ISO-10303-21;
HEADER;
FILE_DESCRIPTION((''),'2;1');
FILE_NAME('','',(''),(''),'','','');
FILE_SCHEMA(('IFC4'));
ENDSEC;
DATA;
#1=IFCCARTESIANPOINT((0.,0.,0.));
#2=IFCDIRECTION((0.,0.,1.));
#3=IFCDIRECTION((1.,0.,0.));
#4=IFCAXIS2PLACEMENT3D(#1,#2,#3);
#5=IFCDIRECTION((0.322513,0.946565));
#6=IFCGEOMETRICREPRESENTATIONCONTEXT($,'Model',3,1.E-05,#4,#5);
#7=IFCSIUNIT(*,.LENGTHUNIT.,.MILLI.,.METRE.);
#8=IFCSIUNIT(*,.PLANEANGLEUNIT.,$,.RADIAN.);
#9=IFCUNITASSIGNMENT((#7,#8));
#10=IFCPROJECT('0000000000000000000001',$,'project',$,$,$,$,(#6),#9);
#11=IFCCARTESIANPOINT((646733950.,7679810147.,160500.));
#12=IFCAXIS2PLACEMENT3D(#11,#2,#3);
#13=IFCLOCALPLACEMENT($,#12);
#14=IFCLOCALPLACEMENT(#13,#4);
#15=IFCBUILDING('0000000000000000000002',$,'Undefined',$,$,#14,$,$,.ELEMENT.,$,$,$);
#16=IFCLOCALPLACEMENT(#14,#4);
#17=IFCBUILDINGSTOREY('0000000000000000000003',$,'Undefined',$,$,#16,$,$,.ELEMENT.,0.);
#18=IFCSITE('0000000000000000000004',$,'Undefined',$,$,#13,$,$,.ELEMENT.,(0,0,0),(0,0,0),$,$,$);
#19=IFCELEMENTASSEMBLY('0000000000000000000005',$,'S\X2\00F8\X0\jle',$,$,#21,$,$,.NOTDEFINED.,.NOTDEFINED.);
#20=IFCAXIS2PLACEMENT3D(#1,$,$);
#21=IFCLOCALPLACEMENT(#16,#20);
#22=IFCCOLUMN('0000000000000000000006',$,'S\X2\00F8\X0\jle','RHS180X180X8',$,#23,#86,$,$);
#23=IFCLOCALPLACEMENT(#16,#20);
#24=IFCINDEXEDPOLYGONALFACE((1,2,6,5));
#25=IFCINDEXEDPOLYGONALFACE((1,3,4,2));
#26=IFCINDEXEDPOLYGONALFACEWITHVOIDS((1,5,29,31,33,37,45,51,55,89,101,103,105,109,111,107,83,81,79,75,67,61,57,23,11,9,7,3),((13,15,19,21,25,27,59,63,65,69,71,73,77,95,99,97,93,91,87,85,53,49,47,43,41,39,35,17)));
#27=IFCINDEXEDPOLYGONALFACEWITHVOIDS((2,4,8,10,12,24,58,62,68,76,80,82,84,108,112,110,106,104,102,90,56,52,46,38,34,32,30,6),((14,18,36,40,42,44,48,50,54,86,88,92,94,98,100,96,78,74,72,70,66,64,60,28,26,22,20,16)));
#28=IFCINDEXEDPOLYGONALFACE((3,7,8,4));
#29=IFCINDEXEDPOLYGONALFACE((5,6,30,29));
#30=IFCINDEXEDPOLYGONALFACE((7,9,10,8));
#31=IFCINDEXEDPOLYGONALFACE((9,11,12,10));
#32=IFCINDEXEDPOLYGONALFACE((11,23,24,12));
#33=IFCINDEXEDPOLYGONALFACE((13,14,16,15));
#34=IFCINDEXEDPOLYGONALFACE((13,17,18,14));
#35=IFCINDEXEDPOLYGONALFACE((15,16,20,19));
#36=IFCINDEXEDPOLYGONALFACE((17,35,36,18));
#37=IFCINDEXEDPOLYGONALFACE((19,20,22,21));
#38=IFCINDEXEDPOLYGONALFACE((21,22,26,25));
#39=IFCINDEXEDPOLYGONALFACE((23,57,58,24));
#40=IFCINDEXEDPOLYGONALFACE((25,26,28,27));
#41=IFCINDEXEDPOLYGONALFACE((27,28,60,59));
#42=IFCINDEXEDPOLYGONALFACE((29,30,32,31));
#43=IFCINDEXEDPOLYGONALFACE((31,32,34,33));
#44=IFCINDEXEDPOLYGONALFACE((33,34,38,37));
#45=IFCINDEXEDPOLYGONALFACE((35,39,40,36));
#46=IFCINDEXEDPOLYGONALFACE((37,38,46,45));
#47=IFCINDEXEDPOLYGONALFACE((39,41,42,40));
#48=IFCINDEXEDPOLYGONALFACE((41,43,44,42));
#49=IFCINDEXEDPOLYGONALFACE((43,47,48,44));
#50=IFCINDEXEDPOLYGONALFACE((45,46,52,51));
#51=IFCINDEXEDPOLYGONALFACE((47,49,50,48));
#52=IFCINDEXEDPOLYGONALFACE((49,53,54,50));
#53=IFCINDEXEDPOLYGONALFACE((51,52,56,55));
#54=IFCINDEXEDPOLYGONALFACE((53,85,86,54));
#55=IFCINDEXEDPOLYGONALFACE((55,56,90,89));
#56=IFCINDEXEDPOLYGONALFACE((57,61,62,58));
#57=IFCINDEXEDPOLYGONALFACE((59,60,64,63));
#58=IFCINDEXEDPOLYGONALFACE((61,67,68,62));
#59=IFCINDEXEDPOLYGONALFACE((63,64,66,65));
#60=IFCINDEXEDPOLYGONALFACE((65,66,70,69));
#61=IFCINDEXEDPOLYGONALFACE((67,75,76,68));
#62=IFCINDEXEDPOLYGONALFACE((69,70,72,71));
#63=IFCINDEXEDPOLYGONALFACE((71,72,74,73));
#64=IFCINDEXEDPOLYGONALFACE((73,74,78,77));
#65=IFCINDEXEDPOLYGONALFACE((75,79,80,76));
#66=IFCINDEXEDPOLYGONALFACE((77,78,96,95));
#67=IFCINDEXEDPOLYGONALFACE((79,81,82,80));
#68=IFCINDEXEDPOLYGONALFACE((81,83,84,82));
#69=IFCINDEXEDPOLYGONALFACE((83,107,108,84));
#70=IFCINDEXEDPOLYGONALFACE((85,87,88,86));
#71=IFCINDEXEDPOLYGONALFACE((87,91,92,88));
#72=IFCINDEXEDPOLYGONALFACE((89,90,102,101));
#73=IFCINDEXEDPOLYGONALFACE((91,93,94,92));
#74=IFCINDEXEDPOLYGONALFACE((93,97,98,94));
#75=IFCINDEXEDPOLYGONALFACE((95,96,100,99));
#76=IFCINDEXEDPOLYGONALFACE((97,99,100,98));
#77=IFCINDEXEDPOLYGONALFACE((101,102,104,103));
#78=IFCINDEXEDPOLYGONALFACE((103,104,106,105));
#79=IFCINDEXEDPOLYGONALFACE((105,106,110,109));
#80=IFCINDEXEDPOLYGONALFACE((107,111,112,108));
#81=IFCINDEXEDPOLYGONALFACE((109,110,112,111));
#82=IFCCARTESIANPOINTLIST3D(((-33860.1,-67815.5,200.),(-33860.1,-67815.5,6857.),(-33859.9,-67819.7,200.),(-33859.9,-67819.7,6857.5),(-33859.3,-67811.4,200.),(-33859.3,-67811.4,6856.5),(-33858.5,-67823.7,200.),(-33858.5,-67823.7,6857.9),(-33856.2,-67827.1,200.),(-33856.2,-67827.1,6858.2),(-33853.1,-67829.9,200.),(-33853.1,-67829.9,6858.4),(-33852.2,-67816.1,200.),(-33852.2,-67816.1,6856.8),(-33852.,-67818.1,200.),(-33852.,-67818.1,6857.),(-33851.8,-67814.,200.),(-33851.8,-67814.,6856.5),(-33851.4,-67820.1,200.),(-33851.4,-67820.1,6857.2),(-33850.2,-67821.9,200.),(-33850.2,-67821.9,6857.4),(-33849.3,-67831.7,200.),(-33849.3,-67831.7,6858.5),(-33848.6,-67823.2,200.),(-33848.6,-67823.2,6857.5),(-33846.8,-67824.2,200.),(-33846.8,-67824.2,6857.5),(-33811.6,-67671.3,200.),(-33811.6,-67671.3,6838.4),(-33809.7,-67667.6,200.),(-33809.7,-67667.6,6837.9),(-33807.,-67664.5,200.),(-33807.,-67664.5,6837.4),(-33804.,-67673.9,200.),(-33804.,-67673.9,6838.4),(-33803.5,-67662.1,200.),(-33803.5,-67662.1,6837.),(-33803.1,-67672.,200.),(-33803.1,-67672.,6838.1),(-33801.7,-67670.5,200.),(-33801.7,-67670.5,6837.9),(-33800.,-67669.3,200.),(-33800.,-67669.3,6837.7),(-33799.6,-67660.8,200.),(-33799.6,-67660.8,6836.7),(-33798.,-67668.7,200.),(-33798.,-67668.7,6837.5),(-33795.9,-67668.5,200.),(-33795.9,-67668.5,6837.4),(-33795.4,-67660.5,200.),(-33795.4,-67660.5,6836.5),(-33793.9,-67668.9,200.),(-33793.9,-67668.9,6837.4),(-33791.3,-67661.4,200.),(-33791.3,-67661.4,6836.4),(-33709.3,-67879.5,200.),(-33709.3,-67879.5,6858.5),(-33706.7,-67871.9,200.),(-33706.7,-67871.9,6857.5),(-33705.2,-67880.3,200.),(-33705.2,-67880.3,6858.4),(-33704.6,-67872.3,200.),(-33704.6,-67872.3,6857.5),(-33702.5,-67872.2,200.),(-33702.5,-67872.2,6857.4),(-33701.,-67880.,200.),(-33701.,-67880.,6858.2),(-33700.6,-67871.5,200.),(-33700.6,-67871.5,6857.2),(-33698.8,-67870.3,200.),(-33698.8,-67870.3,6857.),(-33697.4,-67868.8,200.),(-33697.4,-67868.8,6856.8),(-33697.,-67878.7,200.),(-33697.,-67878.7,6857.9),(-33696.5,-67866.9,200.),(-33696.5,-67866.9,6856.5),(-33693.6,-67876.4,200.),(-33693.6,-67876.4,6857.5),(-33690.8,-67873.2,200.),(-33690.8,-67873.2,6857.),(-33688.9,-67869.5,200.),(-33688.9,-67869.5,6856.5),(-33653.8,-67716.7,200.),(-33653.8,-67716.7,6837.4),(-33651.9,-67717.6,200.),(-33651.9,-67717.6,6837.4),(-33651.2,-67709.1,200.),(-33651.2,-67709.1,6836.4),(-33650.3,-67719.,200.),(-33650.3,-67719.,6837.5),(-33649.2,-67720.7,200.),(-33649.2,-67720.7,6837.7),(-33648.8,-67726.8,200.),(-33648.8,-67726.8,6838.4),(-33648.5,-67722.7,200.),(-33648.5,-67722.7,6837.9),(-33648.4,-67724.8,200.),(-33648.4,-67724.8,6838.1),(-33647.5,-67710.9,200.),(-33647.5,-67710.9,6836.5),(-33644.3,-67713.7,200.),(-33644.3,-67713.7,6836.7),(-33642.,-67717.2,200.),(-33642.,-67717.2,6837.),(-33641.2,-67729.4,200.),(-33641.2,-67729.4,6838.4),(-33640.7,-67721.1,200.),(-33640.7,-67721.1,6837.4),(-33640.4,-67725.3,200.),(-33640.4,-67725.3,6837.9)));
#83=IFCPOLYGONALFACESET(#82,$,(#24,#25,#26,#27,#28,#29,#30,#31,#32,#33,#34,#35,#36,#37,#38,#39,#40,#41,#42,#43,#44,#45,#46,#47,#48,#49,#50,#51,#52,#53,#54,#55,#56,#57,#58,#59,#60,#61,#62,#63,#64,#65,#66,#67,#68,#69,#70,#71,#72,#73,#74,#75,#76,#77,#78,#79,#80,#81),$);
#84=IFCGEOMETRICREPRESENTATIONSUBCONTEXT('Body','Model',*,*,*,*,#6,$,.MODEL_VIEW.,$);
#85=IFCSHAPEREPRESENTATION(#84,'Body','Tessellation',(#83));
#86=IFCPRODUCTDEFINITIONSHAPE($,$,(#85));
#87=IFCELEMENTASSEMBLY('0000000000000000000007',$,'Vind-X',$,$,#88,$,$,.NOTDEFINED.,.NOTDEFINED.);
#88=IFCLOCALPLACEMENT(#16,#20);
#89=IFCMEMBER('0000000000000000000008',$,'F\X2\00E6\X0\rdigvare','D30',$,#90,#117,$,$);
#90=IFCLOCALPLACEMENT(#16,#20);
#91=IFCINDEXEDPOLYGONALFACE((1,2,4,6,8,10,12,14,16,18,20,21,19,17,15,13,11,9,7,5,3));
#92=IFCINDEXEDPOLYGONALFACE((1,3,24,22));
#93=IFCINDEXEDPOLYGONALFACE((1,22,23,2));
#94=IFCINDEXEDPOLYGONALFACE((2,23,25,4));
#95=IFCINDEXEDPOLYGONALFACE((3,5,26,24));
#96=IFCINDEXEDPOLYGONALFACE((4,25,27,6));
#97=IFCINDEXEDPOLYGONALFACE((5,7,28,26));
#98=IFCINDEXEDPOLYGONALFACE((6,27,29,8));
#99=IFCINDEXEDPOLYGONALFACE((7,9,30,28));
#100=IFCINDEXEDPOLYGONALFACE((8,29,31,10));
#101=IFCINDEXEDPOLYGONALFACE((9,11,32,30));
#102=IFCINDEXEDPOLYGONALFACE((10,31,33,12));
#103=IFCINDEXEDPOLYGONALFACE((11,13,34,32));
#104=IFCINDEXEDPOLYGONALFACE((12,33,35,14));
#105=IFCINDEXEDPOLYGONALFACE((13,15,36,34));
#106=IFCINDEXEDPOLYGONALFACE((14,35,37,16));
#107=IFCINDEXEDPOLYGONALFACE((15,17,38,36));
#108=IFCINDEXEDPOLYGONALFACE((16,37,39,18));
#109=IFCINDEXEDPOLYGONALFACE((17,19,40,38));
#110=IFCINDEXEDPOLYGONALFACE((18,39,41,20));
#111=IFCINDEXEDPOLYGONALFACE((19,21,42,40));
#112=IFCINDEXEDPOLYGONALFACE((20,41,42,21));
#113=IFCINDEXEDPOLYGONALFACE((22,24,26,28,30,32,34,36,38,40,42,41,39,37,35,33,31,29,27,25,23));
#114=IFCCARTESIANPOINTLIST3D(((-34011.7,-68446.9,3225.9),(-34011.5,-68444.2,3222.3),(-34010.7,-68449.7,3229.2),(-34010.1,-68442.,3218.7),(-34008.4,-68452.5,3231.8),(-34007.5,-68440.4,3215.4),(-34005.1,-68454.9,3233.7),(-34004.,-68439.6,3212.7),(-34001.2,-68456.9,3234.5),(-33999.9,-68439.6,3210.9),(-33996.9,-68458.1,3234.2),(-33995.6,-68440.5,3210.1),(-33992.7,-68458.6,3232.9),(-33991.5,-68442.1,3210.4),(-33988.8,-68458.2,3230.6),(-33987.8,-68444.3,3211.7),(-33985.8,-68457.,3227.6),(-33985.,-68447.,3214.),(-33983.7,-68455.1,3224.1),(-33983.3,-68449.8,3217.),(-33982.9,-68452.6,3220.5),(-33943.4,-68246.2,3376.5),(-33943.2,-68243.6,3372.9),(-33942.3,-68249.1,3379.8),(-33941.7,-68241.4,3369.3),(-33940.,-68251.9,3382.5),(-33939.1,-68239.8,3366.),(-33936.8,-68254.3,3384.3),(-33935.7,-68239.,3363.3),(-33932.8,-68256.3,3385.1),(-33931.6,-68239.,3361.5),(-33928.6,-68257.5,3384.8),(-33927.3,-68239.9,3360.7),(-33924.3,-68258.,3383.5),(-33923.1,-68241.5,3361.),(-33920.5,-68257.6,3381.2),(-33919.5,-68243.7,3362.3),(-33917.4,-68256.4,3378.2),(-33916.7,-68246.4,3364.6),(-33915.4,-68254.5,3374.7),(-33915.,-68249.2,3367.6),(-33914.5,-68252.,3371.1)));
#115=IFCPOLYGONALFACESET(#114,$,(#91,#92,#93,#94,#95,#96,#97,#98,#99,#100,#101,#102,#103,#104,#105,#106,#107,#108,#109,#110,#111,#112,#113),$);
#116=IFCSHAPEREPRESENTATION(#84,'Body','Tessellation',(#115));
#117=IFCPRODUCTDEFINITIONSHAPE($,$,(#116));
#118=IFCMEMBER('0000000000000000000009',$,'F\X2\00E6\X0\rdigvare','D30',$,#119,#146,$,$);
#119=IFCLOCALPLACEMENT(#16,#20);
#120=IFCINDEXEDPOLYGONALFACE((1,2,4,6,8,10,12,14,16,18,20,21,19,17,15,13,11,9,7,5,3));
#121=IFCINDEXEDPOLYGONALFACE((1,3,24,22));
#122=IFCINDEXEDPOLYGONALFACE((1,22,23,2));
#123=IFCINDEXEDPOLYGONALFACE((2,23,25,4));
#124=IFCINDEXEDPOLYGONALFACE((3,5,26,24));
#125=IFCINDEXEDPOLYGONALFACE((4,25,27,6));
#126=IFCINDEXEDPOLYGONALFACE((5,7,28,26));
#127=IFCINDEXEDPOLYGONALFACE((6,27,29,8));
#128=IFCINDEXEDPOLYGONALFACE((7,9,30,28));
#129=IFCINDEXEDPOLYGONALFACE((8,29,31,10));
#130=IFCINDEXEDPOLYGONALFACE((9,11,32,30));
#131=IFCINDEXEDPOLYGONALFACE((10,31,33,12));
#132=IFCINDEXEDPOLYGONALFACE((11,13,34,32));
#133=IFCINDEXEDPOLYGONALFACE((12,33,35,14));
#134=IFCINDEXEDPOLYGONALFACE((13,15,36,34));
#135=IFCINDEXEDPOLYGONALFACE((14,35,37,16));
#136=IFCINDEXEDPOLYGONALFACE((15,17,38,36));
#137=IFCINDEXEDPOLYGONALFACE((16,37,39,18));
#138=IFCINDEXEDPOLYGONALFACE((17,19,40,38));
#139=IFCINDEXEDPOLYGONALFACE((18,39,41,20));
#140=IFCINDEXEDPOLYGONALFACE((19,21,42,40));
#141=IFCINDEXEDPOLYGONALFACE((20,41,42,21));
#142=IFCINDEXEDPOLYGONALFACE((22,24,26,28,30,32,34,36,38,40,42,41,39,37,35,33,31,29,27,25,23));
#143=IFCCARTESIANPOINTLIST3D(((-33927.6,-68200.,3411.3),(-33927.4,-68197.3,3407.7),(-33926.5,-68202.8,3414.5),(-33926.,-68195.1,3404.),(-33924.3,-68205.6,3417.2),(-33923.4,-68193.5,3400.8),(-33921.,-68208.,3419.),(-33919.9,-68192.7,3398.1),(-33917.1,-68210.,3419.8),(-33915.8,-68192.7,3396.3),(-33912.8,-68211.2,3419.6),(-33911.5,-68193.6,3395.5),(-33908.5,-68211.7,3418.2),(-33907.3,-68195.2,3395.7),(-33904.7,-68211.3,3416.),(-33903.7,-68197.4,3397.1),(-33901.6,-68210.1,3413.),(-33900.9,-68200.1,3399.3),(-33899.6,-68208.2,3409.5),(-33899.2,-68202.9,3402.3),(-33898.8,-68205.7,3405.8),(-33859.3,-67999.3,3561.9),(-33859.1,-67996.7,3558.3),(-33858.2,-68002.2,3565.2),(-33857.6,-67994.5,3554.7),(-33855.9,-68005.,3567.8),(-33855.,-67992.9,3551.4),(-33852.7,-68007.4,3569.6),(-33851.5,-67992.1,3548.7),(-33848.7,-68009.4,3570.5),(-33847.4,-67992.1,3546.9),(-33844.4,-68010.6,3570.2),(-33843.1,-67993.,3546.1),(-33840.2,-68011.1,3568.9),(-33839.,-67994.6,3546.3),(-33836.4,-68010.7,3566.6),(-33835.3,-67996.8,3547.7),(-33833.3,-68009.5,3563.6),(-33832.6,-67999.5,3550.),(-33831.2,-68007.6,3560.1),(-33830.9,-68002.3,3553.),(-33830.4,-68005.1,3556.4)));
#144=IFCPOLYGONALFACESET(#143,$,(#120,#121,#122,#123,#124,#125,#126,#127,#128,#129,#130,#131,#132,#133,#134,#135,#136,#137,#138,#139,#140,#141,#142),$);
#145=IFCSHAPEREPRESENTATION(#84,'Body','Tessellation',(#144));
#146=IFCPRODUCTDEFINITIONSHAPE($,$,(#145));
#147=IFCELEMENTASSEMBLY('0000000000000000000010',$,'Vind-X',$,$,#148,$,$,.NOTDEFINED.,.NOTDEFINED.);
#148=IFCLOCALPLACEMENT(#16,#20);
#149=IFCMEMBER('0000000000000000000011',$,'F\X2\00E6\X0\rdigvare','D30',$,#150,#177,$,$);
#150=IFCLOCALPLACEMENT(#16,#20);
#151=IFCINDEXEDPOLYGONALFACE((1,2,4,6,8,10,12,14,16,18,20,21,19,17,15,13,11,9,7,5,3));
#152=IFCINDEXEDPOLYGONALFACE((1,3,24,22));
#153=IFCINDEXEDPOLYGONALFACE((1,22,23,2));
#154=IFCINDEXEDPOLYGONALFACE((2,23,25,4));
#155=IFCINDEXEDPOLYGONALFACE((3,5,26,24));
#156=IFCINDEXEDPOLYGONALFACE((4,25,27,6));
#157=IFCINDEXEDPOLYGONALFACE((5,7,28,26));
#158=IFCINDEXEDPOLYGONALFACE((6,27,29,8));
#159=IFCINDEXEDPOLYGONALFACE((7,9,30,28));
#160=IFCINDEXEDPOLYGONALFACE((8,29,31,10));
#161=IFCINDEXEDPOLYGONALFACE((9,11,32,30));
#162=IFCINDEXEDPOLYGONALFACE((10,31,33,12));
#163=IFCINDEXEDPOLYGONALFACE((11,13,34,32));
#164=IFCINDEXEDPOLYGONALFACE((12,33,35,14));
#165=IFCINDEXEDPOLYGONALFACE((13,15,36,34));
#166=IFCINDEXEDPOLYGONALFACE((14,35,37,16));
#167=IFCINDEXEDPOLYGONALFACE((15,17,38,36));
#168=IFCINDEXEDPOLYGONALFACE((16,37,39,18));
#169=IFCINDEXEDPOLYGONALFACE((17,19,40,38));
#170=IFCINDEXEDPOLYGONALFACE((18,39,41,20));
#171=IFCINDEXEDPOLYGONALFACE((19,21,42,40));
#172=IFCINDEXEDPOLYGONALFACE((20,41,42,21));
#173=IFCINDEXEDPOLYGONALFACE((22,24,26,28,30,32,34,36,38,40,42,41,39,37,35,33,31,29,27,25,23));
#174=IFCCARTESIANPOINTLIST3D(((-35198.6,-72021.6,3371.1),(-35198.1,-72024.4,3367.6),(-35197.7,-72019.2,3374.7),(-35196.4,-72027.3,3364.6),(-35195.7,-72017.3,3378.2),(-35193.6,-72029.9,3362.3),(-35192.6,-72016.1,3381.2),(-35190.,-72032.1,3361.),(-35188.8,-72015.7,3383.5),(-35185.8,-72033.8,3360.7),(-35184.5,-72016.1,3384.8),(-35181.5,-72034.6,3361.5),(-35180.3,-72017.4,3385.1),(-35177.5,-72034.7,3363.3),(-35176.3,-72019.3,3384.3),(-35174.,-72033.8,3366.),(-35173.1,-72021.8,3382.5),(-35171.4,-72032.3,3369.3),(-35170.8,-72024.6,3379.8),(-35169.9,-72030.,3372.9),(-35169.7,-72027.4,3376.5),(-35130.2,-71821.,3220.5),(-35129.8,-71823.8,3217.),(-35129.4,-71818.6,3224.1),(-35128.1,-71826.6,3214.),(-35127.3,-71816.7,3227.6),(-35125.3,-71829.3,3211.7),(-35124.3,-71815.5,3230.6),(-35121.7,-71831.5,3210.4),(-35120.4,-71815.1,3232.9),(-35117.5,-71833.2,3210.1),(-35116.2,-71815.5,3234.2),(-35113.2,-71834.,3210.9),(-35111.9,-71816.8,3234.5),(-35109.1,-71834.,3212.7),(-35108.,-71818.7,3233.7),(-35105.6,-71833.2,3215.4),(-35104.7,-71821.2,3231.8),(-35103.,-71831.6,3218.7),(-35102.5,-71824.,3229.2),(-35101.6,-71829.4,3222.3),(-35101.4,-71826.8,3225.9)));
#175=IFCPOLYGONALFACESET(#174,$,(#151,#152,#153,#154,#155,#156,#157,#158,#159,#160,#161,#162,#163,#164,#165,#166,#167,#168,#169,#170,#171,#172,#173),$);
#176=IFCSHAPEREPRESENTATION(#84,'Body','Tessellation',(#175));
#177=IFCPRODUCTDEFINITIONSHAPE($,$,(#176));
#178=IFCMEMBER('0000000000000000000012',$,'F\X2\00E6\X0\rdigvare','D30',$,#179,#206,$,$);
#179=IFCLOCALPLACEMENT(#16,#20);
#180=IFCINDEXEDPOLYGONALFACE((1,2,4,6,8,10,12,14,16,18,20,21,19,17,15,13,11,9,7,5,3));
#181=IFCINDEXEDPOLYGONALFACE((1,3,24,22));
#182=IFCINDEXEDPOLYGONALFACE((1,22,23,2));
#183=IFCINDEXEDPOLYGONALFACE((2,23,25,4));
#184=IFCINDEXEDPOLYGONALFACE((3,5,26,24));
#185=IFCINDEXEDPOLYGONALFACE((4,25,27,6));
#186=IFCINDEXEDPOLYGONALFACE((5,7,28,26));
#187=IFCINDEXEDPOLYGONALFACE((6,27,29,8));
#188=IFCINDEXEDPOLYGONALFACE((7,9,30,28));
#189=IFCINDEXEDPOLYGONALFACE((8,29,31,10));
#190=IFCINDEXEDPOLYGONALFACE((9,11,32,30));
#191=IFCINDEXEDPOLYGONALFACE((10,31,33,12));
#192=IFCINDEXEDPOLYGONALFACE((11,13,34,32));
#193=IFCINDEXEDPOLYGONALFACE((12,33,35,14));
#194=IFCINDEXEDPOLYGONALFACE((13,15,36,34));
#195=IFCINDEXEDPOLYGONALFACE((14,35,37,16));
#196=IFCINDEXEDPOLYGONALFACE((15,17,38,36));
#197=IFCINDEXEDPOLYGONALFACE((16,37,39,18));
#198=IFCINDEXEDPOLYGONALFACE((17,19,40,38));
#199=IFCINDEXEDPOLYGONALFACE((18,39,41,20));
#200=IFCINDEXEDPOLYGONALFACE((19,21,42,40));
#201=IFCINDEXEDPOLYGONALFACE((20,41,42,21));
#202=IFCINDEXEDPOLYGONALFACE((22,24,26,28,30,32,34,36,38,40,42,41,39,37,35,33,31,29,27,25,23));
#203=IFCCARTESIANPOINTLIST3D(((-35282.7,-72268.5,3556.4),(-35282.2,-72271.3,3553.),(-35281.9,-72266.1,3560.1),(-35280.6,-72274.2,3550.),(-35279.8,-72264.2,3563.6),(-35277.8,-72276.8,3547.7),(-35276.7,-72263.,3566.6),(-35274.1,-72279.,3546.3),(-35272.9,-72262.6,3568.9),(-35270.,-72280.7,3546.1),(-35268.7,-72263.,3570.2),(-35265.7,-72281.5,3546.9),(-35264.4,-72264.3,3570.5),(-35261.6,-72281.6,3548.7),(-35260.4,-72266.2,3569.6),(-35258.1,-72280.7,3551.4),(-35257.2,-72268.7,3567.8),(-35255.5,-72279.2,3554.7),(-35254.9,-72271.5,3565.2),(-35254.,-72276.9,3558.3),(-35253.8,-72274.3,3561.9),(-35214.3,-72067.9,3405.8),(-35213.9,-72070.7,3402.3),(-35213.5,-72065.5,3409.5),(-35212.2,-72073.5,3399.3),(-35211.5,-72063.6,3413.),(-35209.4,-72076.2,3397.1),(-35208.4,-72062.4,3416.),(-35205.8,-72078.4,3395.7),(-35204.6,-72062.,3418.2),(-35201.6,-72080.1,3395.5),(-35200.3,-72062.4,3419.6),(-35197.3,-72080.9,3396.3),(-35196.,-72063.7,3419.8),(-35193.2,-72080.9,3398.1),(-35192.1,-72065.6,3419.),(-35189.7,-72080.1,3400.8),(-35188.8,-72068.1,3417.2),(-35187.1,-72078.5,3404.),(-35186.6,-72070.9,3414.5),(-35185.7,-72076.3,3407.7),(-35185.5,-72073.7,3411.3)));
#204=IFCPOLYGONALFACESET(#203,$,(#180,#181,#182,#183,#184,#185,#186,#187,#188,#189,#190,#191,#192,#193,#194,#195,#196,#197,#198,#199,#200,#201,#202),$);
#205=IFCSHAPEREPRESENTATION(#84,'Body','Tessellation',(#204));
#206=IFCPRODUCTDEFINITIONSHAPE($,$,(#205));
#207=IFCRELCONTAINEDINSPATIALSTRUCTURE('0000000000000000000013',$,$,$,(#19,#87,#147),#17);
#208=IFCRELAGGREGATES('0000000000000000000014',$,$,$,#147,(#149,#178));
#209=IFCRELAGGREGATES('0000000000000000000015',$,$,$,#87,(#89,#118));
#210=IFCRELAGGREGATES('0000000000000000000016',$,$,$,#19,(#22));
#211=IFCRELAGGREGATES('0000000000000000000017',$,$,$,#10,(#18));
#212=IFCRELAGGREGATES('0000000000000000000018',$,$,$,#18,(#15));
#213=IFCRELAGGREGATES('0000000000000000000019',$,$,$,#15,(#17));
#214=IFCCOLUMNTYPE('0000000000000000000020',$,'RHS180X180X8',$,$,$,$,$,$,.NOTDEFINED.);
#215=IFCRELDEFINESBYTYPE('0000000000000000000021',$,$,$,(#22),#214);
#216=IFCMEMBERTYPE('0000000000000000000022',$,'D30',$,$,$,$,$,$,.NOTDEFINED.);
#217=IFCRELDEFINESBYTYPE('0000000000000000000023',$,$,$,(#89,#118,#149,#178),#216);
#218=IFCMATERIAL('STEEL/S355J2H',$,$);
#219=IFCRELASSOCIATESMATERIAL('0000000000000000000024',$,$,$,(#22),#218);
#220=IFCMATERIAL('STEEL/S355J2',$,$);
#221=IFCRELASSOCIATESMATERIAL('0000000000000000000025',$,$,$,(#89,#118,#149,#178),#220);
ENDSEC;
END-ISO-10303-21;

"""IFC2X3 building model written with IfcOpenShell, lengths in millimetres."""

from ifc_helpers import new_model, si_unit, direction, frame, origin_with_axes, origin_2d_with_axis, place, context, subcontext, project, spatial, hollow_rectangle, circle, extrude, clip, halfspace, material, type_object, element, aggregate, save


model = new_model("IFC2X3")

# Units and contexts
model_context = context("Model", 3, precision=1e-05, world=origin_with_axes(), true_north=direction((0.322513, 0.946565)))
body_context = subcontext(model_context, "Body", "Model", "MODEL_VIEW")
ifc_project = project(units=[si_unit("LENGTHUNIT", "METRE", prefix="MILLI"), si_unit("PLANEANGLEUNIT", "RADIAN")], contexts=[model_context])

# Site, building, storey
site_placement = place(None, frame((646733950.0, 7679810147.0, 160500.0), z_axis=(0.0, 0.0, 1.0), x_axis=(1.0, 0.0, 0.0)))
site = spatial("IfcSite", under=ifc_project, at=site_placement, Name="Undefined", CompositionType="ELEMENT", RefLatitude=(0, 0, 0), RefLongitude=(0, 0, 0))
building_placement = place(site_placement, origin_with_axes())
building = spatial("IfcBuilding", under=site, at=building_placement, Name="Undefined", CompositionType="ELEMENT")
storey_placement = place(building_placement, origin_with_axes())
storey = spatial("IfcBuildingStorey", under=building, at=storey_placement, Name="Undefined", CompositionType="ELEMENT", Elevation=0.0)

# Element assembly, column
assembly_1_placement = place(storey_placement, origin_with_axes())
assembly_1 = element("IfcElementAssembly", 1, at=assembly_1_placement, inside=storey, Name="Søjle", AssemblyPlace="NOTDEFINED", PredefinedType="NOTDEFINED")
ifc_material_1 = material(Name="STEEL/S355J2H")
column_type = type_object("IfcColumnType", Name="RHS180X180X8", PredefinedType="NOTDEFINED")
column_placement = place(assembly_1_placement, frame((-33750.3, -67770.4, 200.0), z_axis=(0.0, 0.0, 1.0), x_axis=(0.322513, 0.946565, 0.0)))
column = element("IfcColumn", 2, at=column_placement, type_object=column_type, material=ifc_material_1, Name="Søjle", Description="RHS180X180X8", context=body_context, shape_type="Clipping", body=[
    clip(extrude(hollow_rectangle(XDim=180.0, YDim=180.0, WallThickness=8.0, InnerFilletRadius=8.0, OuterFilletRadius=16.0, at=origin_2d_with_axis()), frame((0.0, 0.0, 6658.6), z_axis=(0.0, 0.0, -1.0), x_axis=(0.0, 1.0, 0.0)), (0.0, 0.0, 1.0), 6658.6), halfspace(frame((90.0, 0.0, 6636.4), z_axis=(-0.121869, 0.0, -0.992546), x_axis=(0.0, 1.0, 0.0)), True)),
])

# Element assemblies, members
assembly_2_placement = place(storey_placement, origin_with_axes())
assembly_2 = element("IfcElementAssembly", 3, at=assembly_2_placement, inside=storey, Name="Vind-X", AssemblyPlace="NOTDEFINED", PredefinedType="NOTDEFINED")
ifc_material_2 = material(Name="STEEL/S355J2")
member_type_1 = type_object("IfcMemberType", Name="D30", PredefinedType="NOTDEFINED")
member_1_placement = place(assembly_2_placement, frame((-33929.0, -68248.4, 3372.9), z_axis=(-0.186826, -0.548329, 0.815126), x_axis=(-0.262889, -0.77157, -0.579283)))
member_1 = element("IfcMember", 4, at=member_1_placement, type_object=member_type_1, material=ifc_material_2, Name="Færdigvare", Description="D30", context=body_context, shape_type="SweptSolid", body=[
    extrude(circle(Radius=15.0, at=origin_2d_with_axis()), frame((260.0, 0.0, 0.0), z_axis=(-1.0, 0.0, 0.0), x_axis=(0.0, -1.0, 0.0)), (0.0, 0.0, 1.0), 260.0),
])
member_2_placement = place(assembly_2_placement, frame((-33844.9, -68001.5, 3558.3), z_axis=(-0.186827, -0.54833, 0.815126), x_axis=(-0.262889, -0.77157, -0.579284)))
member_2 = element("IfcMember", 5, at=member_2_placement, type_object=member_type_1, material=ifc_material_2, Name="Færdigvare", Description="D30", context=body_context, shape_type="SweptSolid", body=[
    extrude(circle(Radius=15.0, at=origin_2d_with_axis()), frame((260.0, 0.0, 0.0), z_axis=(-1.0, 0.0, 0.0), x_axis=(0.0, -1.0, 0.0)), (0.0, 0.0, 1.0), 260.0),
])
assembly_3_placement = place(storey_placement, origin_with_axes())
assembly_3 = element("IfcElementAssembly", 6, at=assembly_3_placement, inside=storey, Name="Vind-X", AssemblyPlace="NOTDEFINED", PredefinedType="NOTDEFINED")
member_3_placement = place(assembly_3_placement, frame((-35184.1, -72025.2, 3372.9), z_axis=(0.186826, 0.548329, 0.815126), x_axis=(0.262889, 0.77157, -0.579283)))
member_3 = element("IfcMember", 7, at=member_3_placement, type_object=member_type_1, material=ifc_material_2, Name="Færdigvare", Description="D30", context=body_context, shape_type="SweptSolid", body=[
    extrude(circle(Radius=15.0, at=origin_2d_with_axis()), frame((260.0, 0.0, 0.0), z_axis=(-1.0, 0.0, 0.0), x_axis=(0.0, -1.0, 0.0)), (0.0, 0.0, 1.0), 260.0),
])
member_4_placement = place(assembly_3_placement, frame((-35268.2, -72272.1, 3558.3), z_axis=(0.186827, 0.54833, 0.815126), x_axis=(0.262889, 0.77157, -0.579284)))
member_4 = element("IfcMember", 8, at=member_4_placement, type_object=member_type_1, material=ifc_material_2, Name="Færdigvare", Description="D30", context=body_context, shape_type="SweptSolid", body=[
    extrude(circle(Radius=15.0, at=origin_2d_with_axis()), frame((260.0, 0.0, 0.0), z_axis=(-1.0, 0.0, 0.0), x_axis=(0.0, -1.0, 0.0)), (0.0, 0.0, 1.0), 260.0),
])

aggregate(assembly_3, [member_3, member_4])
aggregate(assembly_2, [member_1, member_2])
aggregate(assembly_1, [column])

save(model, "model.ifc")
